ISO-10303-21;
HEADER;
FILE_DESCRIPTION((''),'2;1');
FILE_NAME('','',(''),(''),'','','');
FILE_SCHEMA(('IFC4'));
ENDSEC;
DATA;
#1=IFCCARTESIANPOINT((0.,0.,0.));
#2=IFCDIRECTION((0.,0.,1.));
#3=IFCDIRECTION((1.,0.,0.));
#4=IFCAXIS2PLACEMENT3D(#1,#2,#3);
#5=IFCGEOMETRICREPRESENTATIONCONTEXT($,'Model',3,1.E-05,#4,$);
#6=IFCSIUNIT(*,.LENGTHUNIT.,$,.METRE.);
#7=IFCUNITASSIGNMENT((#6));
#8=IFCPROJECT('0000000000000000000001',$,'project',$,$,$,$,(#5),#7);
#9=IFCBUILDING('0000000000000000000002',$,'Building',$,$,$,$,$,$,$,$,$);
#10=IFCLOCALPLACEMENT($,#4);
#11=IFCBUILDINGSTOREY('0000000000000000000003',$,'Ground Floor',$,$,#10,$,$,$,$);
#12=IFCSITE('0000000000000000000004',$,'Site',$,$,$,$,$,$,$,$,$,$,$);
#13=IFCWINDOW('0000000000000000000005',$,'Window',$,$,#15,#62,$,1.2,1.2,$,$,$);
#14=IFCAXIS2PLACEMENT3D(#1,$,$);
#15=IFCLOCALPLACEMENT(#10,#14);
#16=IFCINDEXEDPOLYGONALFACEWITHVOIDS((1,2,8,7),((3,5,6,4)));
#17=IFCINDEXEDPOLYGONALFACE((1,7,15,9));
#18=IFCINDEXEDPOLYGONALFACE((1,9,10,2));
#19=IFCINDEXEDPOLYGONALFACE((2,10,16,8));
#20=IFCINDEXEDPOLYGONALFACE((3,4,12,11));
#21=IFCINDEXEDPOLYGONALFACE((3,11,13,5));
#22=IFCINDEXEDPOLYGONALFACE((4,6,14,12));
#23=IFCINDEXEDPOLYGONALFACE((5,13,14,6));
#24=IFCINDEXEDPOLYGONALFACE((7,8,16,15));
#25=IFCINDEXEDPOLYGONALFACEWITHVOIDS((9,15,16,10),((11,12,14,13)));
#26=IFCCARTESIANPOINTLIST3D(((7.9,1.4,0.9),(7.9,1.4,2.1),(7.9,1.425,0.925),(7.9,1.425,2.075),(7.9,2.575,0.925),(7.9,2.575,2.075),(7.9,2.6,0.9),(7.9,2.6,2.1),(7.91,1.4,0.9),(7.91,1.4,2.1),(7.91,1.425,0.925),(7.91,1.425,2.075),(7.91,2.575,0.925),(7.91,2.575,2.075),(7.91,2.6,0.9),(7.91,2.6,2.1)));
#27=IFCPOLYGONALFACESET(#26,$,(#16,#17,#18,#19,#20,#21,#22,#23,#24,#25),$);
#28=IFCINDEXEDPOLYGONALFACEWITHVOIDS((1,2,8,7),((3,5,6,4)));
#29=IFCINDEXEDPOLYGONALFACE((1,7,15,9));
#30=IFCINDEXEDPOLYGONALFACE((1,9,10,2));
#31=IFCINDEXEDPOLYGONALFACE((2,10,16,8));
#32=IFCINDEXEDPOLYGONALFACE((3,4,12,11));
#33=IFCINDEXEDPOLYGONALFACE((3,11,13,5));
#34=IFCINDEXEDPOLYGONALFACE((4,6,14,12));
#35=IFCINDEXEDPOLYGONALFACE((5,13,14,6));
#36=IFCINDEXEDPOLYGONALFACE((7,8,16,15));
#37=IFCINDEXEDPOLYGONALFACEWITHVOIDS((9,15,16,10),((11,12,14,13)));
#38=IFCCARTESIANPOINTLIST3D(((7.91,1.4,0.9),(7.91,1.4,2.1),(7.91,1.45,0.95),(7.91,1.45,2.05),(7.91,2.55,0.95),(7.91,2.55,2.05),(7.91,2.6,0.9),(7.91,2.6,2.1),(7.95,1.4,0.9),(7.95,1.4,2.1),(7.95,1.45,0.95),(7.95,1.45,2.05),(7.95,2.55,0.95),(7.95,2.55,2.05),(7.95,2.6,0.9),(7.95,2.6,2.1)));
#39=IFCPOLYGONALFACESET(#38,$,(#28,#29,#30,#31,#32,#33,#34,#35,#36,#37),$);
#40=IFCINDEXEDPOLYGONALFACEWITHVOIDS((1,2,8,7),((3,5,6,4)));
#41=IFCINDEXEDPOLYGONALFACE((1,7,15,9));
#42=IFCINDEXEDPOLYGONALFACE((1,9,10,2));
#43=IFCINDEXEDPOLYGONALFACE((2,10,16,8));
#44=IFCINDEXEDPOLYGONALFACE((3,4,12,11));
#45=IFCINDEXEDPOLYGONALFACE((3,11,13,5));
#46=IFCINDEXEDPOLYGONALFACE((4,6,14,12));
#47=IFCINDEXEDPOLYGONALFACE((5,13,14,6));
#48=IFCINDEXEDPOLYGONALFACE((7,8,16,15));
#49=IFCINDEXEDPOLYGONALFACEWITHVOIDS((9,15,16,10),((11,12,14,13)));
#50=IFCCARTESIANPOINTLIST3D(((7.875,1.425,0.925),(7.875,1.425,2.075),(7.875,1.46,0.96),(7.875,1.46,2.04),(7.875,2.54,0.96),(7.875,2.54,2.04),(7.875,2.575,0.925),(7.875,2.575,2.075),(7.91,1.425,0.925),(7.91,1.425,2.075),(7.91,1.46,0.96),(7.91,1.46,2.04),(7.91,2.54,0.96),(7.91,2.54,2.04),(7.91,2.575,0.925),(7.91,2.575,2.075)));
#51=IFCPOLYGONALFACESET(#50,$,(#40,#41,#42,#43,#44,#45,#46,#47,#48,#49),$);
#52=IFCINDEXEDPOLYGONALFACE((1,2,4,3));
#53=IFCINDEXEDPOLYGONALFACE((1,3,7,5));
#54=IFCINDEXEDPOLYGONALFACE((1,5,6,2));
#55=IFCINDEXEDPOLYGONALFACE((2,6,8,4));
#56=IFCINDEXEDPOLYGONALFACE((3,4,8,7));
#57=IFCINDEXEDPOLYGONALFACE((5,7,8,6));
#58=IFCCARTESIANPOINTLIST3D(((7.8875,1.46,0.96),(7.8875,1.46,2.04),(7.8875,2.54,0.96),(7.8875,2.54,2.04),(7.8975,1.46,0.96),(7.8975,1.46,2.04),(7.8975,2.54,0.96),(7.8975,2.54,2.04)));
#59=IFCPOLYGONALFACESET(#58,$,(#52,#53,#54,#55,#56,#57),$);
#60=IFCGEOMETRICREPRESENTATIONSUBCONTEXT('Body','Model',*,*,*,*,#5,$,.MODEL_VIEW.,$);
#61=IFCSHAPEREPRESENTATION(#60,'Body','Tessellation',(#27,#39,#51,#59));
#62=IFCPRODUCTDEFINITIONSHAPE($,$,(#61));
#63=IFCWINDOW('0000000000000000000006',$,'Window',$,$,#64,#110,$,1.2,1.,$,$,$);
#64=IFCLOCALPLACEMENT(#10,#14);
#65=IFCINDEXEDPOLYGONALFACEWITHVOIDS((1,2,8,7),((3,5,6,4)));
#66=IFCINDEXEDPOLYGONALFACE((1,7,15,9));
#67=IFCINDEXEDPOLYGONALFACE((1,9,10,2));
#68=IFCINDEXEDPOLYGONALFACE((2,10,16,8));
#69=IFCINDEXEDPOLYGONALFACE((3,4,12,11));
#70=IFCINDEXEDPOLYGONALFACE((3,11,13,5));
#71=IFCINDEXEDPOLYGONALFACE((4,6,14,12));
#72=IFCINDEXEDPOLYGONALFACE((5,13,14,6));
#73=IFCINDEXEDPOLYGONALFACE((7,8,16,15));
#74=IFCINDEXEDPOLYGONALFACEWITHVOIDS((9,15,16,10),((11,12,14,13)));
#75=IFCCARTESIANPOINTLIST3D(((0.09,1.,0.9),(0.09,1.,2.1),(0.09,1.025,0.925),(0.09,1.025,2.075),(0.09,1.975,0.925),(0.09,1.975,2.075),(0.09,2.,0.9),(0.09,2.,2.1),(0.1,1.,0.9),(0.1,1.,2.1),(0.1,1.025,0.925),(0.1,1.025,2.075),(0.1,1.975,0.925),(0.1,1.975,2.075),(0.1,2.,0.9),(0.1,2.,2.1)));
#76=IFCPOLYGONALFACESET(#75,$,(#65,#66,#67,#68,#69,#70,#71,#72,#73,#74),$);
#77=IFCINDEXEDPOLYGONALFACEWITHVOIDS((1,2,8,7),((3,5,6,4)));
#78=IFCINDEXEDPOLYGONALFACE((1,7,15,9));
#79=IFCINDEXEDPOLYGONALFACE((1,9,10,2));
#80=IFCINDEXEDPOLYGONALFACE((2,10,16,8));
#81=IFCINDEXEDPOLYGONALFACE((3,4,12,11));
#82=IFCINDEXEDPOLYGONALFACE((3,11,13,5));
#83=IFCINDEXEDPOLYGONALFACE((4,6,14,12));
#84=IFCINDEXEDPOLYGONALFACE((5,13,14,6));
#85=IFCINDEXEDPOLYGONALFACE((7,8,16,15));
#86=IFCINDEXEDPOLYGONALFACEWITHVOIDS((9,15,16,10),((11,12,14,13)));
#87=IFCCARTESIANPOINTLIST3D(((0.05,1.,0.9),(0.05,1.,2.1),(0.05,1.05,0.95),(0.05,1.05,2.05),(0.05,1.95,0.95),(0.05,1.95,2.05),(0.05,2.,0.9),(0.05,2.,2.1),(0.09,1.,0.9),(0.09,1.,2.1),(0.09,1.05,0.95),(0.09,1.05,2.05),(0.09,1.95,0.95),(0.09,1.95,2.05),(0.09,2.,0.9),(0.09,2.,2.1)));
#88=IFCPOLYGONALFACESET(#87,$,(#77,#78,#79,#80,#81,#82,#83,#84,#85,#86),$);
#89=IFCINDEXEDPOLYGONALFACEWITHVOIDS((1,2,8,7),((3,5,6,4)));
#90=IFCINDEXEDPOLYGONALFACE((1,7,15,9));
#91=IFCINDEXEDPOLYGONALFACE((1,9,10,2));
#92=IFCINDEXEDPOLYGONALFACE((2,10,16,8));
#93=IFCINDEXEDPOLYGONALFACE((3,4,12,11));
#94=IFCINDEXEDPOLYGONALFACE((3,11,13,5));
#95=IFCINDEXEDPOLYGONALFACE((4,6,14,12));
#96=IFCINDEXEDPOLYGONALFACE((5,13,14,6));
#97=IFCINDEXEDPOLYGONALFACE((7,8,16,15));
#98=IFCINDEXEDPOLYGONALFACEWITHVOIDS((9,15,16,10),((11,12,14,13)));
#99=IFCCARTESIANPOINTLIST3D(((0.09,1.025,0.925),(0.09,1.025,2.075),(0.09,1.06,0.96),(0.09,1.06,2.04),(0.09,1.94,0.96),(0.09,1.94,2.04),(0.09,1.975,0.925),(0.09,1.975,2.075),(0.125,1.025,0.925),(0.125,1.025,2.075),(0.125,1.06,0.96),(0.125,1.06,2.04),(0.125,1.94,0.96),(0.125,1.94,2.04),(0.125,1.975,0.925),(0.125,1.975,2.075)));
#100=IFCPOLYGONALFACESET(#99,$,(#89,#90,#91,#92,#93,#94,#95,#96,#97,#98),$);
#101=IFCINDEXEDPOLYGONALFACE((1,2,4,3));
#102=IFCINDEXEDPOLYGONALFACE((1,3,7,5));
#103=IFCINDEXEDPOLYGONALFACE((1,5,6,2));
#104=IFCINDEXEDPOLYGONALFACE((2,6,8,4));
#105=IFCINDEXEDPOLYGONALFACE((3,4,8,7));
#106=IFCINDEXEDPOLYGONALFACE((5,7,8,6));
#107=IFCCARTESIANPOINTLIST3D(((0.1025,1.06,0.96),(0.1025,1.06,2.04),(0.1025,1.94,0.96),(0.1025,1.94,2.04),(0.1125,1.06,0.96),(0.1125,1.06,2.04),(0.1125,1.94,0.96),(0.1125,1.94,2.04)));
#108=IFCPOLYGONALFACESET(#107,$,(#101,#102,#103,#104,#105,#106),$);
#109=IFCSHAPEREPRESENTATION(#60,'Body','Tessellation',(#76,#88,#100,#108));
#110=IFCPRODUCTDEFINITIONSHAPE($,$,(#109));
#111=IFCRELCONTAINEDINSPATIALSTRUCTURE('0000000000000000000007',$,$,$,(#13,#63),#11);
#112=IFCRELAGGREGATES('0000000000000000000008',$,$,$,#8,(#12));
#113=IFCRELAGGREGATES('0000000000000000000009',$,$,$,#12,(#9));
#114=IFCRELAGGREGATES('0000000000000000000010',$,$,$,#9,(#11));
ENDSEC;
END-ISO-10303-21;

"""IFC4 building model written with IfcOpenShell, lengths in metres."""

from ifc_helpers import new_model, si_unit, frame, origin_with_axes, place, context, subcontext, project, spatial, line, indexed_curve, outline, extrude, element, save


model = new_model("IFC4")

# Units and contexts
model_context = context("Model", 3, precision=1e-05, world=origin_with_axes())
body_context = subcontext(model_context, "Body", "Model", "MODEL_VIEW")
ifc_project = project(units=[si_unit("LENGTHUNIT", "METRE")], contexts=[model_context])

# Site, building, storey
site = spatial("IfcSite", under=ifc_project, Name="Site")
building = spatial("IfcBuilding", under=site, Name="Building")
storey_placement = place(None, origin_with_axes())
storey = spatial("IfcBuildingStorey", under=building, at=storey_placement, Name="Ground Floor")

# Windows
window_1_placement = place(storey_placement, frame((8.0, 1.4, 0.9), z_axis=(0.0, 0.0, 1.0), x_axis=(0.0, 1.0, 0.0)))
element("IfcWindow", 1, at=window_1_placement, inside=storey, Name="Window", OverallHeight=1.2, OverallWidth=1.2, context=body_context, shape_type="SweptSolid", body=[
    extrude(outline(indexed_curve([(0.0, 0.0), (1.2, 0.0), (1.2, 1.2), (0.0, 1.2)], segments=[line(1, 2, 3, 4, 1)]), holes=[indexed_curve([(0.025, 0.025), (1.175, 0.025), (1.175, 1.175), (0.025, 1.175)], segments=[line(1, 2, 3, 4, 1)])]), frame((0.0, 0.09, 0.0), z_axis=(0.0, -1.0, 0.0), x_axis=(1.0, 0.0, 0.0)), (0.0, 0.0, -1.0), 0.01),
    extrude(outline(indexed_curve([(0.0, 0.0), (1.2, 0.0), (1.2, 1.2), (0.0, 1.2)], segments=[line(1, 2, 3, 4, 1)]), holes=[indexed_curve([(0.05, 0.05), (1.15, 0.05), (1.15, 1.15), (0.05, 1.15)], segments=[line(1, 2, 3, 4, 1)])]), frame((0.0, 0.05, 0.0), z_axis=(0.0, -1.0, 0.0), x_axis=(1.0, 0.0, 0.0)), (0.0, 0.0, -1.0), 0.04),
    extrude(outline(indexed_curve([(0.0, 0.0), (1.15, 0.0), (1.15, 1.15), (0.0, 1.15)], segments=[line(1, 2, 3, 4, 1)]), holes=[indexed_curve([(0.035, 0.035), (1.115, 0.035), (1.115, 1.115), (0.035, 1.115)], segments=[line(1, 2, 3, 4, 1)])]), frame((0.025, 0.09, 0.025), z_axis=(0.0, -1.0, 0.0), x_axis=(1.0, 0.0, 0.0)), (0.0, 0.0, -1.0), 0.035),
    extrude(outline(indexed_curve([(0.035, 0.035), (1.115, 0.035), (1.115, 1.115), (0.035, 1.115)], segments=[line(1, 2, 3, 4, 1)])), frame((0.025, 0.1025, 0.025), z_axis=(0.0, -1.0, 0.0), x_axis=(1.0, 0.0, 0.0)), (0.0, 0.0, -1.0), 0.01),
])
window_2_placement = place(storey_placement, frame((0.0, 2.0, 0.9), z_axis=(0.0, 0.0, 1.0), x_axis=(0.0, -1.0, 0.0)))
element("IfcWindow", 2, at=window_2_placement, inside=storey, Name="Window", OverallHeight=1.2, OverallWidth=1.0, context=body_context, shape_type="SweptSolid", body=[
    extrude(outline(indexed_curve([(0.0, 0.0), (1.0, 0.0), (1.0, 1.2), (0.0, 1.2)], segments=[line(1, 2, 3, 4, 1)]), holes=[indexed_curve([(0.025, 0.025), (0.975, 0.025), (0.975, 1.175), (0.025, 1.175)], segments=[line(1, 2, 3, 4, 1)])]), frame((0.0, 0.09, 0.0), z_axis=(0.0, -1.0, 0.0), x_axis=(1.0, 0.0, 0.0)), (0.0, 0.0, -1.0), 0.01),
    extrude(outline(indexed_curve([(0.0, 0.0), (1.0, 0.0), (1.0, 1.2), (0.0, 1.2)], segments=[line(1, 2, 3, 4, 1)]), holes=[indexed_curve([(0.05, 0.05), (0.95, 0.05), (0.95, 1.15), (0.05, 1.15)], segments=[line(1, 2, 3, 4, 1)])]), frame((0.0, 0.05, 0.0), z_axis=(0.0, -1.0, 0.0), x_axis=(1.0, 0.0, 0.0)), (0.0, 0.0, -1.0), 0.04),
    extrude(outline(indexed_curve([(0.0, 0.0), (0.95, 0.0), (0.95, 1.15), (0.0, 1.15)], segments=[line(1, 2, 3, 4, 1)]), holes=[indexed_curve([(0.035, 0.035), (0.915, 0.035), (0.915, 1.115), (0.035, 1.115)], segments=[line(1, 2, 3, 4, 1)])]), frame((0.025, 0.09, 0.025), z_axis=(0.0, -1.0, 0.0), x_axis=(1.0, 0.0, 0.0)), (0.0, 0.0, -1.0), 0.035),
    extrude(outline(indexed_curve([(0.035, 0.035), (0.915, 0.035), (0.915, 1.115), (0.035, 1.115)], segments=[line(1, 2, 3, 4, 1)])), frame((0.025, 0.1025, 0.025), z_axis=(0.0, -1.0, 0.0), x_axis=(1.0, 0.0, 0.0)), (0.0, 0.0, -1.0), 0.01),
])

save(model, "model.ifc")
